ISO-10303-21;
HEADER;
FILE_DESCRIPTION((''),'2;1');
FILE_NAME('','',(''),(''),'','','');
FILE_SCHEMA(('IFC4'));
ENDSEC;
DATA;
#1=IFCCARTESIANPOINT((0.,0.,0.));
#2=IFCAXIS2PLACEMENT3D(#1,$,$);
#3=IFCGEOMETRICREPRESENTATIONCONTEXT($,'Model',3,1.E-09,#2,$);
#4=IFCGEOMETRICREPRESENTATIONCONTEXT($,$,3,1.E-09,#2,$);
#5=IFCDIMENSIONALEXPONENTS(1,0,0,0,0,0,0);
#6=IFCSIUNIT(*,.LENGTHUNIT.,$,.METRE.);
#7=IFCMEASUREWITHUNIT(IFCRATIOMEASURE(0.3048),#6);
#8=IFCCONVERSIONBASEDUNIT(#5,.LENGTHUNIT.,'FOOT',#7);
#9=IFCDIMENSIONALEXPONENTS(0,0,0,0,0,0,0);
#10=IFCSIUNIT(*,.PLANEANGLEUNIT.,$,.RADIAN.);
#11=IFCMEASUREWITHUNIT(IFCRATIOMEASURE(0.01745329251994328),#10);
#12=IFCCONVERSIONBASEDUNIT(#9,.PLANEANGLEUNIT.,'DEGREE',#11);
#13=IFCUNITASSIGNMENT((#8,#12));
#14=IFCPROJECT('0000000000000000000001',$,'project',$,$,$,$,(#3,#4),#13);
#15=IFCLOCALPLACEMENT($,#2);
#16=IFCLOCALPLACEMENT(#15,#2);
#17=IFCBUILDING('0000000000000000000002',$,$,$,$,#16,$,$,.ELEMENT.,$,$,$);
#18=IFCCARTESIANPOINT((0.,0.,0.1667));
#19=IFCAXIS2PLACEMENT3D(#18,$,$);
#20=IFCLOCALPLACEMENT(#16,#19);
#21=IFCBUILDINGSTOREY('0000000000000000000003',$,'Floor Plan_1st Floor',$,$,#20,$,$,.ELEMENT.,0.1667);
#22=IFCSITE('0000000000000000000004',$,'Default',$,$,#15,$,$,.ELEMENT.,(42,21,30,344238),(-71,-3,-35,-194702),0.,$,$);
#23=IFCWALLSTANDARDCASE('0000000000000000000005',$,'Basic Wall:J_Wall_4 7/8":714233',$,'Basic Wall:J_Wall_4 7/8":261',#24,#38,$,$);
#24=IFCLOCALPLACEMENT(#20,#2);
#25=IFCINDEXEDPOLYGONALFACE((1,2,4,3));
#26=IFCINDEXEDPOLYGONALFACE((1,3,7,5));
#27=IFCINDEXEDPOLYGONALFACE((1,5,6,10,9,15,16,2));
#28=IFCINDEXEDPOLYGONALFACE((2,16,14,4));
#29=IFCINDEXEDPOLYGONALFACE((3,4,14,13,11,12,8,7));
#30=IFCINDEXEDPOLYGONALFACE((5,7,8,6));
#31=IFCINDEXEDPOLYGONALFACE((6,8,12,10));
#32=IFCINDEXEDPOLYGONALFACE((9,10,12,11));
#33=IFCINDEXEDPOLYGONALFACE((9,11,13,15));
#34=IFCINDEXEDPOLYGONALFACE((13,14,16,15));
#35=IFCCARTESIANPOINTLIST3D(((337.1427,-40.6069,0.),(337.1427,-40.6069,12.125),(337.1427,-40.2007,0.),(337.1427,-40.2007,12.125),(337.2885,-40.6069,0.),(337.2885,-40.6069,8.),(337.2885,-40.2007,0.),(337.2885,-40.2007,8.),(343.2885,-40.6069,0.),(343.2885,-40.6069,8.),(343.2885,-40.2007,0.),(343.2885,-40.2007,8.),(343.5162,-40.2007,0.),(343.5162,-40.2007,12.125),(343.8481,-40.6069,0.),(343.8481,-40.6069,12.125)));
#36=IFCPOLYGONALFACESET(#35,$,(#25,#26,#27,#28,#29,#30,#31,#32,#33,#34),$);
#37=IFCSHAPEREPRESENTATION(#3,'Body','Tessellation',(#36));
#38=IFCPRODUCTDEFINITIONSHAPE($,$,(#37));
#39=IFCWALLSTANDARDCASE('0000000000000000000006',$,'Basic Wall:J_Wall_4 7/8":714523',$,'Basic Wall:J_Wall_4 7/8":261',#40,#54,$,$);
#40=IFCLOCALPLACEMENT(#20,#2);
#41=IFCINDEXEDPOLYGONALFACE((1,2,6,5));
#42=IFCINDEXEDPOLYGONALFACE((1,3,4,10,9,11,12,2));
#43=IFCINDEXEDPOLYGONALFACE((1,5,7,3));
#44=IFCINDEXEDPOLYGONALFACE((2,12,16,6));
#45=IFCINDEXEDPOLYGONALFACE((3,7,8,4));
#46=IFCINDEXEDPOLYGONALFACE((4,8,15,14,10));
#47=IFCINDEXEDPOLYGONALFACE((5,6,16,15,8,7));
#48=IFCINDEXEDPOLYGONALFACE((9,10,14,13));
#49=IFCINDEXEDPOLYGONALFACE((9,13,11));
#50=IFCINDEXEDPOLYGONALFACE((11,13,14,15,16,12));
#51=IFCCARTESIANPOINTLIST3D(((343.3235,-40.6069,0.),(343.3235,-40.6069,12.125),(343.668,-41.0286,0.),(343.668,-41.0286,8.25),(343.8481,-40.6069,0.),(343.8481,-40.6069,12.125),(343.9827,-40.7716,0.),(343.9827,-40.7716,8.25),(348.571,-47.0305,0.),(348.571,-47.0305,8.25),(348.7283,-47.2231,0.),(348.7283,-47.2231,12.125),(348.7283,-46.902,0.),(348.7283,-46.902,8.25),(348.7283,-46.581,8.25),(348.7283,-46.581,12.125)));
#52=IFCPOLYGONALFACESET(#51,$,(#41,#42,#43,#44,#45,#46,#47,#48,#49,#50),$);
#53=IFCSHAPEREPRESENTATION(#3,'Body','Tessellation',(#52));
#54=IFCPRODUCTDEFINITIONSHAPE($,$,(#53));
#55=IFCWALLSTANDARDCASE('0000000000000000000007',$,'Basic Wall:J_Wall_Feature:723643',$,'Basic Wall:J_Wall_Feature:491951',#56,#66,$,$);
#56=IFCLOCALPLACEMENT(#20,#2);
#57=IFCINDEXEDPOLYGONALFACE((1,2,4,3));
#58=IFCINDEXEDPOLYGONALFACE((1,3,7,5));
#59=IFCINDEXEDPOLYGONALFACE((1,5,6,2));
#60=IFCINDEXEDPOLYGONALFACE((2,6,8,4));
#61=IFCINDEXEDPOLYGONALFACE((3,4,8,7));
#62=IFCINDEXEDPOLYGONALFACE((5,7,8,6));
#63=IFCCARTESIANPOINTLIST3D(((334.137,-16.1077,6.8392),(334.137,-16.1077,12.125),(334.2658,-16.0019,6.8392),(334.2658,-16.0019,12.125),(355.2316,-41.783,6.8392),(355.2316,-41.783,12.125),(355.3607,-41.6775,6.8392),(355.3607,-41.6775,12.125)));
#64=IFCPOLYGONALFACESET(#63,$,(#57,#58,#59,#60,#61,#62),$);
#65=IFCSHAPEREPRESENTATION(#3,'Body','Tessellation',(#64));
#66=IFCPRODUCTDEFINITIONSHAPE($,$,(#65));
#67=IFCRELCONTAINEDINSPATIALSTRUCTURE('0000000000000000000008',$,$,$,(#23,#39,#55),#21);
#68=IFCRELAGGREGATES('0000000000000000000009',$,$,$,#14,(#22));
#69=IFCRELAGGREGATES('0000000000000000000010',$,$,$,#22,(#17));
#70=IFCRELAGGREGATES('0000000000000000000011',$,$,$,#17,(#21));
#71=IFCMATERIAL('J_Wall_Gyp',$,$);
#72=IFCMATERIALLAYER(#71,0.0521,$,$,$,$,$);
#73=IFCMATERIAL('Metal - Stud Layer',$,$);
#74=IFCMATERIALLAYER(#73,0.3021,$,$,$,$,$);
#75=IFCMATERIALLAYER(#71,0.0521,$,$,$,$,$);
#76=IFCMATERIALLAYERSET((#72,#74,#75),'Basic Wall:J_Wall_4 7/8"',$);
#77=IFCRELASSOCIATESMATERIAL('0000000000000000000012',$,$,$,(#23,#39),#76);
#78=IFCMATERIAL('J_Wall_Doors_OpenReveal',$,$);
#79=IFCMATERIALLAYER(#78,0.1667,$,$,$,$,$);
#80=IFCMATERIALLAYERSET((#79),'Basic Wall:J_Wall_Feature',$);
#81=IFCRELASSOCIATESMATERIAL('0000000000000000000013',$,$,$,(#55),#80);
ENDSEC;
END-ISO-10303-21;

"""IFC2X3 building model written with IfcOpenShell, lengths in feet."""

from ifc_helpers import new_model, entity, si_unit, converted_unit, frame, frame_2d, origin, origin_2d_with_axis, place, context, project, spatial, polyline, rectangle, outline, extrude, material, layer, layer_set, layer_usage, element, save


model = new_model("IFC2X3")

# Units and contexts
model_context = context("Model", 3, precision=1e-09, world=origin())
context_of_model = context(None, 3, precision=1e-09, world=origin())
ifc_project = project(units=[converted_unit("LENGTHUNIT", "FOOT", entity("IfcRatioMeasure", 0.3048), si_unit("LENGTHUNIT", "METRE"), dimensions=[1, 0, 0, 0, 0, 0, 0]), converted_unit("PLANEANGLEUNIT", "DEGREE", entity("IfcRatioMeasure", 0.01745329251994328), si_unit("PLANEANGLEUNIT", "RADIAN"), dimensions=[0, 0, 0, 0, 0, 0, 0])], contexts=[model_context, context_of_model])

# Site, building, storey
site_placement = place(None, origin())
site = spatial("IfcSite", under=ifc_project, at=site_placement, Name="Default", CompositionType="ELEMENT", RefLatitude=(42, 21, 30, 344238), RefLongitude=(-71, -3, -35, -194702), RefElevation=0.0)
building_placement = place(site_placement, origin())
building = spatial("IfcBuilding", under=site, at=building_placement, CompositionType="ELEMENT")
storey_placement = place(building_placement, frame((0.0, 0.0, 0.1667)))
storey = spatial("IfcBuildingStorey", under=building, at=storey_placement, Name="Floor Plan_1st Floor", CompositionType="ELEMENT", Elevation=0.1667)

# Shared definitions
ifc_material_1 = material(Name="J_Wall_Gyp")
ifc_layer_1 = layer(ifc_material_1, 0.0521)
ifc_material_2 = material(Name="Metal - Stud Layer")
ifc_layer_2 = layer(ifc_material_2, 0.3021)
ifc_layer_3 = layer(ifc_material_1, 0.0521)
ifc_layer_set_1 = layer_set([ifc_layer_1, ifc_layer_2, ifc_layer_3], Name="Basic Wall:J_Wall_4 7/8\"")

# Shared definitions
ifc_material_3 = material(Name="J_Wall_Doors_OpenReveal")
ifc_layer_4 = layer(ifc_material_3, 0.1667)
ifc_layer_set_2 = layer_set([ifc_layer_4], Name="Basic Wall:J_Wall_Feature")

# Walls, openings
ifc_layer_usage_1 = layer_usage(ifc_layer_set_1, "AXIS2", "NEGATIVE", 0.2031)
wall_1_placement = place(storey_placement, frame((343.8481, -40.4038, 0.0), z_axis=(0.0, 0.0, 1.0), x_axis=(-1.0, 0.0, 0.0)))
wall_1 = element("IfcWallStandardCase", 1, at=wall_1_placement, inside=storey, material=ifc_layer_usage_1, Name="Basic Wall:J_Wall_4 7/8\":714233", ObjectType="Basic Wall:J_Wall_4 7/8\":261", context=model_context, shape_type="SweptSolid", body=[
    extrude(outline(polyline([(0.3319, -0.2031), (6.7054, -0.2031), (6.7054, 0.2031), (0.5246, 0.2031), (0.0, 0.2031), (0.3319, -0.2031)])), origin(), (0.0, 0.0, 1.0), 12.125),
])
opening_1_placement = place(wall_1_placement, frame((0.5596, -0.2031, 0.0)))
element("IfcOpeningElement", 2, at=opening_1_placement, cuts=wall_1, ObjectType="Opening", context=model_context, shape_type="SweptSolid", body=[
    extrude(rectangle(XDim=8.0, YDim=6.0, at=frame_2d((4.0, 3.0), x_axis=(1.0, 0.0))), frame((0.0, 0.0, 0.0), z_axis=(0.0, 1.0, 0.0), x_axis=(0.0, 0.0, 1.0)), (0.0, 0.0, 1.0), 0.4062),
])
ifc_layer_usage_2 = layer_usage(ifc_layer_set_1, "AXIS2", "NEGATIVE", 0.2031)
wall_2_placement = place(storey_placement, frame((343.4809, -40.4784, 0.0), z_axis=(0.0, 0.0, 1.0), x_axis=(0.632643, -0.774444, 0.0)))
wall_2 = element("IfcWallStandardCase", 3, at=wall_2_placement, inside=storey, material=ifc_layer_usage_2, Name="Basic Wall:J_Wall_4 7/8\":714523", ObjectType="Basic Wall:J_Wall_4 7/8\":261", context=model_context, shape_type="SweptSolid", body=[
    extrude(outline(polyline([(0.0, -0.2031), (8.5432, -0.2031), (8.0459, 0.2031), (0.3319, 0.2031), (0.0, -0.2031)])), origin(), (0.0, 0.0, 1.0), 12.125),
])
opening_2_placement = place(wall_2_placement, origin())
element("IfcOpeningElement", 4, at=opening_2_placement, cuts=wall_2, ObjectType="Opening", context=model_context, shape_type="SweptSolid", body=[
    extrude(rectangle(XDim=8.25, YDim=7.75, at=origin_2d_with_axis()), frame((4.4195, -0.7031, 4.125), z_axis=(0.0, 1.0, 0.0), x_axis=(0.0, 0.0, 1.0)), (0.0, 0.0, 1.0), 1.4062),
])

# Wall
ifc_layer_usage_3 = layer_usage(ifc_layer_set_2, "AXIS2", "NEGATIVE", 0.0833)
wall_3_placement = place(storey_placement, frame((355.2963, -41.7304, 6.8392), z_axis=(0.0, 0.0, 1.0), x_axis=(-0.634816, 0.772664, 0.0)))
element("IfcWallStandardCase", 5, at=wall_3_placement, inside=storey, material=ifc_layer_usage_3, Name="Basic Wall:J_Wall_Feature:723643", ObjectType="Basic Wall:J_Wall_Feature:491951", context=model_context, shape_type="SweptSolid", body=[
    extrude(outline(polyline([(33.23, -0.0833), (33.23, 0.0833), (0.0005, 0.0833), (0.0, -0.0833), (33.23, -0.0833)])), origin(), (0.0, 0.0, 1.0), 5.2858),
])

save(model, "model.ifc")
